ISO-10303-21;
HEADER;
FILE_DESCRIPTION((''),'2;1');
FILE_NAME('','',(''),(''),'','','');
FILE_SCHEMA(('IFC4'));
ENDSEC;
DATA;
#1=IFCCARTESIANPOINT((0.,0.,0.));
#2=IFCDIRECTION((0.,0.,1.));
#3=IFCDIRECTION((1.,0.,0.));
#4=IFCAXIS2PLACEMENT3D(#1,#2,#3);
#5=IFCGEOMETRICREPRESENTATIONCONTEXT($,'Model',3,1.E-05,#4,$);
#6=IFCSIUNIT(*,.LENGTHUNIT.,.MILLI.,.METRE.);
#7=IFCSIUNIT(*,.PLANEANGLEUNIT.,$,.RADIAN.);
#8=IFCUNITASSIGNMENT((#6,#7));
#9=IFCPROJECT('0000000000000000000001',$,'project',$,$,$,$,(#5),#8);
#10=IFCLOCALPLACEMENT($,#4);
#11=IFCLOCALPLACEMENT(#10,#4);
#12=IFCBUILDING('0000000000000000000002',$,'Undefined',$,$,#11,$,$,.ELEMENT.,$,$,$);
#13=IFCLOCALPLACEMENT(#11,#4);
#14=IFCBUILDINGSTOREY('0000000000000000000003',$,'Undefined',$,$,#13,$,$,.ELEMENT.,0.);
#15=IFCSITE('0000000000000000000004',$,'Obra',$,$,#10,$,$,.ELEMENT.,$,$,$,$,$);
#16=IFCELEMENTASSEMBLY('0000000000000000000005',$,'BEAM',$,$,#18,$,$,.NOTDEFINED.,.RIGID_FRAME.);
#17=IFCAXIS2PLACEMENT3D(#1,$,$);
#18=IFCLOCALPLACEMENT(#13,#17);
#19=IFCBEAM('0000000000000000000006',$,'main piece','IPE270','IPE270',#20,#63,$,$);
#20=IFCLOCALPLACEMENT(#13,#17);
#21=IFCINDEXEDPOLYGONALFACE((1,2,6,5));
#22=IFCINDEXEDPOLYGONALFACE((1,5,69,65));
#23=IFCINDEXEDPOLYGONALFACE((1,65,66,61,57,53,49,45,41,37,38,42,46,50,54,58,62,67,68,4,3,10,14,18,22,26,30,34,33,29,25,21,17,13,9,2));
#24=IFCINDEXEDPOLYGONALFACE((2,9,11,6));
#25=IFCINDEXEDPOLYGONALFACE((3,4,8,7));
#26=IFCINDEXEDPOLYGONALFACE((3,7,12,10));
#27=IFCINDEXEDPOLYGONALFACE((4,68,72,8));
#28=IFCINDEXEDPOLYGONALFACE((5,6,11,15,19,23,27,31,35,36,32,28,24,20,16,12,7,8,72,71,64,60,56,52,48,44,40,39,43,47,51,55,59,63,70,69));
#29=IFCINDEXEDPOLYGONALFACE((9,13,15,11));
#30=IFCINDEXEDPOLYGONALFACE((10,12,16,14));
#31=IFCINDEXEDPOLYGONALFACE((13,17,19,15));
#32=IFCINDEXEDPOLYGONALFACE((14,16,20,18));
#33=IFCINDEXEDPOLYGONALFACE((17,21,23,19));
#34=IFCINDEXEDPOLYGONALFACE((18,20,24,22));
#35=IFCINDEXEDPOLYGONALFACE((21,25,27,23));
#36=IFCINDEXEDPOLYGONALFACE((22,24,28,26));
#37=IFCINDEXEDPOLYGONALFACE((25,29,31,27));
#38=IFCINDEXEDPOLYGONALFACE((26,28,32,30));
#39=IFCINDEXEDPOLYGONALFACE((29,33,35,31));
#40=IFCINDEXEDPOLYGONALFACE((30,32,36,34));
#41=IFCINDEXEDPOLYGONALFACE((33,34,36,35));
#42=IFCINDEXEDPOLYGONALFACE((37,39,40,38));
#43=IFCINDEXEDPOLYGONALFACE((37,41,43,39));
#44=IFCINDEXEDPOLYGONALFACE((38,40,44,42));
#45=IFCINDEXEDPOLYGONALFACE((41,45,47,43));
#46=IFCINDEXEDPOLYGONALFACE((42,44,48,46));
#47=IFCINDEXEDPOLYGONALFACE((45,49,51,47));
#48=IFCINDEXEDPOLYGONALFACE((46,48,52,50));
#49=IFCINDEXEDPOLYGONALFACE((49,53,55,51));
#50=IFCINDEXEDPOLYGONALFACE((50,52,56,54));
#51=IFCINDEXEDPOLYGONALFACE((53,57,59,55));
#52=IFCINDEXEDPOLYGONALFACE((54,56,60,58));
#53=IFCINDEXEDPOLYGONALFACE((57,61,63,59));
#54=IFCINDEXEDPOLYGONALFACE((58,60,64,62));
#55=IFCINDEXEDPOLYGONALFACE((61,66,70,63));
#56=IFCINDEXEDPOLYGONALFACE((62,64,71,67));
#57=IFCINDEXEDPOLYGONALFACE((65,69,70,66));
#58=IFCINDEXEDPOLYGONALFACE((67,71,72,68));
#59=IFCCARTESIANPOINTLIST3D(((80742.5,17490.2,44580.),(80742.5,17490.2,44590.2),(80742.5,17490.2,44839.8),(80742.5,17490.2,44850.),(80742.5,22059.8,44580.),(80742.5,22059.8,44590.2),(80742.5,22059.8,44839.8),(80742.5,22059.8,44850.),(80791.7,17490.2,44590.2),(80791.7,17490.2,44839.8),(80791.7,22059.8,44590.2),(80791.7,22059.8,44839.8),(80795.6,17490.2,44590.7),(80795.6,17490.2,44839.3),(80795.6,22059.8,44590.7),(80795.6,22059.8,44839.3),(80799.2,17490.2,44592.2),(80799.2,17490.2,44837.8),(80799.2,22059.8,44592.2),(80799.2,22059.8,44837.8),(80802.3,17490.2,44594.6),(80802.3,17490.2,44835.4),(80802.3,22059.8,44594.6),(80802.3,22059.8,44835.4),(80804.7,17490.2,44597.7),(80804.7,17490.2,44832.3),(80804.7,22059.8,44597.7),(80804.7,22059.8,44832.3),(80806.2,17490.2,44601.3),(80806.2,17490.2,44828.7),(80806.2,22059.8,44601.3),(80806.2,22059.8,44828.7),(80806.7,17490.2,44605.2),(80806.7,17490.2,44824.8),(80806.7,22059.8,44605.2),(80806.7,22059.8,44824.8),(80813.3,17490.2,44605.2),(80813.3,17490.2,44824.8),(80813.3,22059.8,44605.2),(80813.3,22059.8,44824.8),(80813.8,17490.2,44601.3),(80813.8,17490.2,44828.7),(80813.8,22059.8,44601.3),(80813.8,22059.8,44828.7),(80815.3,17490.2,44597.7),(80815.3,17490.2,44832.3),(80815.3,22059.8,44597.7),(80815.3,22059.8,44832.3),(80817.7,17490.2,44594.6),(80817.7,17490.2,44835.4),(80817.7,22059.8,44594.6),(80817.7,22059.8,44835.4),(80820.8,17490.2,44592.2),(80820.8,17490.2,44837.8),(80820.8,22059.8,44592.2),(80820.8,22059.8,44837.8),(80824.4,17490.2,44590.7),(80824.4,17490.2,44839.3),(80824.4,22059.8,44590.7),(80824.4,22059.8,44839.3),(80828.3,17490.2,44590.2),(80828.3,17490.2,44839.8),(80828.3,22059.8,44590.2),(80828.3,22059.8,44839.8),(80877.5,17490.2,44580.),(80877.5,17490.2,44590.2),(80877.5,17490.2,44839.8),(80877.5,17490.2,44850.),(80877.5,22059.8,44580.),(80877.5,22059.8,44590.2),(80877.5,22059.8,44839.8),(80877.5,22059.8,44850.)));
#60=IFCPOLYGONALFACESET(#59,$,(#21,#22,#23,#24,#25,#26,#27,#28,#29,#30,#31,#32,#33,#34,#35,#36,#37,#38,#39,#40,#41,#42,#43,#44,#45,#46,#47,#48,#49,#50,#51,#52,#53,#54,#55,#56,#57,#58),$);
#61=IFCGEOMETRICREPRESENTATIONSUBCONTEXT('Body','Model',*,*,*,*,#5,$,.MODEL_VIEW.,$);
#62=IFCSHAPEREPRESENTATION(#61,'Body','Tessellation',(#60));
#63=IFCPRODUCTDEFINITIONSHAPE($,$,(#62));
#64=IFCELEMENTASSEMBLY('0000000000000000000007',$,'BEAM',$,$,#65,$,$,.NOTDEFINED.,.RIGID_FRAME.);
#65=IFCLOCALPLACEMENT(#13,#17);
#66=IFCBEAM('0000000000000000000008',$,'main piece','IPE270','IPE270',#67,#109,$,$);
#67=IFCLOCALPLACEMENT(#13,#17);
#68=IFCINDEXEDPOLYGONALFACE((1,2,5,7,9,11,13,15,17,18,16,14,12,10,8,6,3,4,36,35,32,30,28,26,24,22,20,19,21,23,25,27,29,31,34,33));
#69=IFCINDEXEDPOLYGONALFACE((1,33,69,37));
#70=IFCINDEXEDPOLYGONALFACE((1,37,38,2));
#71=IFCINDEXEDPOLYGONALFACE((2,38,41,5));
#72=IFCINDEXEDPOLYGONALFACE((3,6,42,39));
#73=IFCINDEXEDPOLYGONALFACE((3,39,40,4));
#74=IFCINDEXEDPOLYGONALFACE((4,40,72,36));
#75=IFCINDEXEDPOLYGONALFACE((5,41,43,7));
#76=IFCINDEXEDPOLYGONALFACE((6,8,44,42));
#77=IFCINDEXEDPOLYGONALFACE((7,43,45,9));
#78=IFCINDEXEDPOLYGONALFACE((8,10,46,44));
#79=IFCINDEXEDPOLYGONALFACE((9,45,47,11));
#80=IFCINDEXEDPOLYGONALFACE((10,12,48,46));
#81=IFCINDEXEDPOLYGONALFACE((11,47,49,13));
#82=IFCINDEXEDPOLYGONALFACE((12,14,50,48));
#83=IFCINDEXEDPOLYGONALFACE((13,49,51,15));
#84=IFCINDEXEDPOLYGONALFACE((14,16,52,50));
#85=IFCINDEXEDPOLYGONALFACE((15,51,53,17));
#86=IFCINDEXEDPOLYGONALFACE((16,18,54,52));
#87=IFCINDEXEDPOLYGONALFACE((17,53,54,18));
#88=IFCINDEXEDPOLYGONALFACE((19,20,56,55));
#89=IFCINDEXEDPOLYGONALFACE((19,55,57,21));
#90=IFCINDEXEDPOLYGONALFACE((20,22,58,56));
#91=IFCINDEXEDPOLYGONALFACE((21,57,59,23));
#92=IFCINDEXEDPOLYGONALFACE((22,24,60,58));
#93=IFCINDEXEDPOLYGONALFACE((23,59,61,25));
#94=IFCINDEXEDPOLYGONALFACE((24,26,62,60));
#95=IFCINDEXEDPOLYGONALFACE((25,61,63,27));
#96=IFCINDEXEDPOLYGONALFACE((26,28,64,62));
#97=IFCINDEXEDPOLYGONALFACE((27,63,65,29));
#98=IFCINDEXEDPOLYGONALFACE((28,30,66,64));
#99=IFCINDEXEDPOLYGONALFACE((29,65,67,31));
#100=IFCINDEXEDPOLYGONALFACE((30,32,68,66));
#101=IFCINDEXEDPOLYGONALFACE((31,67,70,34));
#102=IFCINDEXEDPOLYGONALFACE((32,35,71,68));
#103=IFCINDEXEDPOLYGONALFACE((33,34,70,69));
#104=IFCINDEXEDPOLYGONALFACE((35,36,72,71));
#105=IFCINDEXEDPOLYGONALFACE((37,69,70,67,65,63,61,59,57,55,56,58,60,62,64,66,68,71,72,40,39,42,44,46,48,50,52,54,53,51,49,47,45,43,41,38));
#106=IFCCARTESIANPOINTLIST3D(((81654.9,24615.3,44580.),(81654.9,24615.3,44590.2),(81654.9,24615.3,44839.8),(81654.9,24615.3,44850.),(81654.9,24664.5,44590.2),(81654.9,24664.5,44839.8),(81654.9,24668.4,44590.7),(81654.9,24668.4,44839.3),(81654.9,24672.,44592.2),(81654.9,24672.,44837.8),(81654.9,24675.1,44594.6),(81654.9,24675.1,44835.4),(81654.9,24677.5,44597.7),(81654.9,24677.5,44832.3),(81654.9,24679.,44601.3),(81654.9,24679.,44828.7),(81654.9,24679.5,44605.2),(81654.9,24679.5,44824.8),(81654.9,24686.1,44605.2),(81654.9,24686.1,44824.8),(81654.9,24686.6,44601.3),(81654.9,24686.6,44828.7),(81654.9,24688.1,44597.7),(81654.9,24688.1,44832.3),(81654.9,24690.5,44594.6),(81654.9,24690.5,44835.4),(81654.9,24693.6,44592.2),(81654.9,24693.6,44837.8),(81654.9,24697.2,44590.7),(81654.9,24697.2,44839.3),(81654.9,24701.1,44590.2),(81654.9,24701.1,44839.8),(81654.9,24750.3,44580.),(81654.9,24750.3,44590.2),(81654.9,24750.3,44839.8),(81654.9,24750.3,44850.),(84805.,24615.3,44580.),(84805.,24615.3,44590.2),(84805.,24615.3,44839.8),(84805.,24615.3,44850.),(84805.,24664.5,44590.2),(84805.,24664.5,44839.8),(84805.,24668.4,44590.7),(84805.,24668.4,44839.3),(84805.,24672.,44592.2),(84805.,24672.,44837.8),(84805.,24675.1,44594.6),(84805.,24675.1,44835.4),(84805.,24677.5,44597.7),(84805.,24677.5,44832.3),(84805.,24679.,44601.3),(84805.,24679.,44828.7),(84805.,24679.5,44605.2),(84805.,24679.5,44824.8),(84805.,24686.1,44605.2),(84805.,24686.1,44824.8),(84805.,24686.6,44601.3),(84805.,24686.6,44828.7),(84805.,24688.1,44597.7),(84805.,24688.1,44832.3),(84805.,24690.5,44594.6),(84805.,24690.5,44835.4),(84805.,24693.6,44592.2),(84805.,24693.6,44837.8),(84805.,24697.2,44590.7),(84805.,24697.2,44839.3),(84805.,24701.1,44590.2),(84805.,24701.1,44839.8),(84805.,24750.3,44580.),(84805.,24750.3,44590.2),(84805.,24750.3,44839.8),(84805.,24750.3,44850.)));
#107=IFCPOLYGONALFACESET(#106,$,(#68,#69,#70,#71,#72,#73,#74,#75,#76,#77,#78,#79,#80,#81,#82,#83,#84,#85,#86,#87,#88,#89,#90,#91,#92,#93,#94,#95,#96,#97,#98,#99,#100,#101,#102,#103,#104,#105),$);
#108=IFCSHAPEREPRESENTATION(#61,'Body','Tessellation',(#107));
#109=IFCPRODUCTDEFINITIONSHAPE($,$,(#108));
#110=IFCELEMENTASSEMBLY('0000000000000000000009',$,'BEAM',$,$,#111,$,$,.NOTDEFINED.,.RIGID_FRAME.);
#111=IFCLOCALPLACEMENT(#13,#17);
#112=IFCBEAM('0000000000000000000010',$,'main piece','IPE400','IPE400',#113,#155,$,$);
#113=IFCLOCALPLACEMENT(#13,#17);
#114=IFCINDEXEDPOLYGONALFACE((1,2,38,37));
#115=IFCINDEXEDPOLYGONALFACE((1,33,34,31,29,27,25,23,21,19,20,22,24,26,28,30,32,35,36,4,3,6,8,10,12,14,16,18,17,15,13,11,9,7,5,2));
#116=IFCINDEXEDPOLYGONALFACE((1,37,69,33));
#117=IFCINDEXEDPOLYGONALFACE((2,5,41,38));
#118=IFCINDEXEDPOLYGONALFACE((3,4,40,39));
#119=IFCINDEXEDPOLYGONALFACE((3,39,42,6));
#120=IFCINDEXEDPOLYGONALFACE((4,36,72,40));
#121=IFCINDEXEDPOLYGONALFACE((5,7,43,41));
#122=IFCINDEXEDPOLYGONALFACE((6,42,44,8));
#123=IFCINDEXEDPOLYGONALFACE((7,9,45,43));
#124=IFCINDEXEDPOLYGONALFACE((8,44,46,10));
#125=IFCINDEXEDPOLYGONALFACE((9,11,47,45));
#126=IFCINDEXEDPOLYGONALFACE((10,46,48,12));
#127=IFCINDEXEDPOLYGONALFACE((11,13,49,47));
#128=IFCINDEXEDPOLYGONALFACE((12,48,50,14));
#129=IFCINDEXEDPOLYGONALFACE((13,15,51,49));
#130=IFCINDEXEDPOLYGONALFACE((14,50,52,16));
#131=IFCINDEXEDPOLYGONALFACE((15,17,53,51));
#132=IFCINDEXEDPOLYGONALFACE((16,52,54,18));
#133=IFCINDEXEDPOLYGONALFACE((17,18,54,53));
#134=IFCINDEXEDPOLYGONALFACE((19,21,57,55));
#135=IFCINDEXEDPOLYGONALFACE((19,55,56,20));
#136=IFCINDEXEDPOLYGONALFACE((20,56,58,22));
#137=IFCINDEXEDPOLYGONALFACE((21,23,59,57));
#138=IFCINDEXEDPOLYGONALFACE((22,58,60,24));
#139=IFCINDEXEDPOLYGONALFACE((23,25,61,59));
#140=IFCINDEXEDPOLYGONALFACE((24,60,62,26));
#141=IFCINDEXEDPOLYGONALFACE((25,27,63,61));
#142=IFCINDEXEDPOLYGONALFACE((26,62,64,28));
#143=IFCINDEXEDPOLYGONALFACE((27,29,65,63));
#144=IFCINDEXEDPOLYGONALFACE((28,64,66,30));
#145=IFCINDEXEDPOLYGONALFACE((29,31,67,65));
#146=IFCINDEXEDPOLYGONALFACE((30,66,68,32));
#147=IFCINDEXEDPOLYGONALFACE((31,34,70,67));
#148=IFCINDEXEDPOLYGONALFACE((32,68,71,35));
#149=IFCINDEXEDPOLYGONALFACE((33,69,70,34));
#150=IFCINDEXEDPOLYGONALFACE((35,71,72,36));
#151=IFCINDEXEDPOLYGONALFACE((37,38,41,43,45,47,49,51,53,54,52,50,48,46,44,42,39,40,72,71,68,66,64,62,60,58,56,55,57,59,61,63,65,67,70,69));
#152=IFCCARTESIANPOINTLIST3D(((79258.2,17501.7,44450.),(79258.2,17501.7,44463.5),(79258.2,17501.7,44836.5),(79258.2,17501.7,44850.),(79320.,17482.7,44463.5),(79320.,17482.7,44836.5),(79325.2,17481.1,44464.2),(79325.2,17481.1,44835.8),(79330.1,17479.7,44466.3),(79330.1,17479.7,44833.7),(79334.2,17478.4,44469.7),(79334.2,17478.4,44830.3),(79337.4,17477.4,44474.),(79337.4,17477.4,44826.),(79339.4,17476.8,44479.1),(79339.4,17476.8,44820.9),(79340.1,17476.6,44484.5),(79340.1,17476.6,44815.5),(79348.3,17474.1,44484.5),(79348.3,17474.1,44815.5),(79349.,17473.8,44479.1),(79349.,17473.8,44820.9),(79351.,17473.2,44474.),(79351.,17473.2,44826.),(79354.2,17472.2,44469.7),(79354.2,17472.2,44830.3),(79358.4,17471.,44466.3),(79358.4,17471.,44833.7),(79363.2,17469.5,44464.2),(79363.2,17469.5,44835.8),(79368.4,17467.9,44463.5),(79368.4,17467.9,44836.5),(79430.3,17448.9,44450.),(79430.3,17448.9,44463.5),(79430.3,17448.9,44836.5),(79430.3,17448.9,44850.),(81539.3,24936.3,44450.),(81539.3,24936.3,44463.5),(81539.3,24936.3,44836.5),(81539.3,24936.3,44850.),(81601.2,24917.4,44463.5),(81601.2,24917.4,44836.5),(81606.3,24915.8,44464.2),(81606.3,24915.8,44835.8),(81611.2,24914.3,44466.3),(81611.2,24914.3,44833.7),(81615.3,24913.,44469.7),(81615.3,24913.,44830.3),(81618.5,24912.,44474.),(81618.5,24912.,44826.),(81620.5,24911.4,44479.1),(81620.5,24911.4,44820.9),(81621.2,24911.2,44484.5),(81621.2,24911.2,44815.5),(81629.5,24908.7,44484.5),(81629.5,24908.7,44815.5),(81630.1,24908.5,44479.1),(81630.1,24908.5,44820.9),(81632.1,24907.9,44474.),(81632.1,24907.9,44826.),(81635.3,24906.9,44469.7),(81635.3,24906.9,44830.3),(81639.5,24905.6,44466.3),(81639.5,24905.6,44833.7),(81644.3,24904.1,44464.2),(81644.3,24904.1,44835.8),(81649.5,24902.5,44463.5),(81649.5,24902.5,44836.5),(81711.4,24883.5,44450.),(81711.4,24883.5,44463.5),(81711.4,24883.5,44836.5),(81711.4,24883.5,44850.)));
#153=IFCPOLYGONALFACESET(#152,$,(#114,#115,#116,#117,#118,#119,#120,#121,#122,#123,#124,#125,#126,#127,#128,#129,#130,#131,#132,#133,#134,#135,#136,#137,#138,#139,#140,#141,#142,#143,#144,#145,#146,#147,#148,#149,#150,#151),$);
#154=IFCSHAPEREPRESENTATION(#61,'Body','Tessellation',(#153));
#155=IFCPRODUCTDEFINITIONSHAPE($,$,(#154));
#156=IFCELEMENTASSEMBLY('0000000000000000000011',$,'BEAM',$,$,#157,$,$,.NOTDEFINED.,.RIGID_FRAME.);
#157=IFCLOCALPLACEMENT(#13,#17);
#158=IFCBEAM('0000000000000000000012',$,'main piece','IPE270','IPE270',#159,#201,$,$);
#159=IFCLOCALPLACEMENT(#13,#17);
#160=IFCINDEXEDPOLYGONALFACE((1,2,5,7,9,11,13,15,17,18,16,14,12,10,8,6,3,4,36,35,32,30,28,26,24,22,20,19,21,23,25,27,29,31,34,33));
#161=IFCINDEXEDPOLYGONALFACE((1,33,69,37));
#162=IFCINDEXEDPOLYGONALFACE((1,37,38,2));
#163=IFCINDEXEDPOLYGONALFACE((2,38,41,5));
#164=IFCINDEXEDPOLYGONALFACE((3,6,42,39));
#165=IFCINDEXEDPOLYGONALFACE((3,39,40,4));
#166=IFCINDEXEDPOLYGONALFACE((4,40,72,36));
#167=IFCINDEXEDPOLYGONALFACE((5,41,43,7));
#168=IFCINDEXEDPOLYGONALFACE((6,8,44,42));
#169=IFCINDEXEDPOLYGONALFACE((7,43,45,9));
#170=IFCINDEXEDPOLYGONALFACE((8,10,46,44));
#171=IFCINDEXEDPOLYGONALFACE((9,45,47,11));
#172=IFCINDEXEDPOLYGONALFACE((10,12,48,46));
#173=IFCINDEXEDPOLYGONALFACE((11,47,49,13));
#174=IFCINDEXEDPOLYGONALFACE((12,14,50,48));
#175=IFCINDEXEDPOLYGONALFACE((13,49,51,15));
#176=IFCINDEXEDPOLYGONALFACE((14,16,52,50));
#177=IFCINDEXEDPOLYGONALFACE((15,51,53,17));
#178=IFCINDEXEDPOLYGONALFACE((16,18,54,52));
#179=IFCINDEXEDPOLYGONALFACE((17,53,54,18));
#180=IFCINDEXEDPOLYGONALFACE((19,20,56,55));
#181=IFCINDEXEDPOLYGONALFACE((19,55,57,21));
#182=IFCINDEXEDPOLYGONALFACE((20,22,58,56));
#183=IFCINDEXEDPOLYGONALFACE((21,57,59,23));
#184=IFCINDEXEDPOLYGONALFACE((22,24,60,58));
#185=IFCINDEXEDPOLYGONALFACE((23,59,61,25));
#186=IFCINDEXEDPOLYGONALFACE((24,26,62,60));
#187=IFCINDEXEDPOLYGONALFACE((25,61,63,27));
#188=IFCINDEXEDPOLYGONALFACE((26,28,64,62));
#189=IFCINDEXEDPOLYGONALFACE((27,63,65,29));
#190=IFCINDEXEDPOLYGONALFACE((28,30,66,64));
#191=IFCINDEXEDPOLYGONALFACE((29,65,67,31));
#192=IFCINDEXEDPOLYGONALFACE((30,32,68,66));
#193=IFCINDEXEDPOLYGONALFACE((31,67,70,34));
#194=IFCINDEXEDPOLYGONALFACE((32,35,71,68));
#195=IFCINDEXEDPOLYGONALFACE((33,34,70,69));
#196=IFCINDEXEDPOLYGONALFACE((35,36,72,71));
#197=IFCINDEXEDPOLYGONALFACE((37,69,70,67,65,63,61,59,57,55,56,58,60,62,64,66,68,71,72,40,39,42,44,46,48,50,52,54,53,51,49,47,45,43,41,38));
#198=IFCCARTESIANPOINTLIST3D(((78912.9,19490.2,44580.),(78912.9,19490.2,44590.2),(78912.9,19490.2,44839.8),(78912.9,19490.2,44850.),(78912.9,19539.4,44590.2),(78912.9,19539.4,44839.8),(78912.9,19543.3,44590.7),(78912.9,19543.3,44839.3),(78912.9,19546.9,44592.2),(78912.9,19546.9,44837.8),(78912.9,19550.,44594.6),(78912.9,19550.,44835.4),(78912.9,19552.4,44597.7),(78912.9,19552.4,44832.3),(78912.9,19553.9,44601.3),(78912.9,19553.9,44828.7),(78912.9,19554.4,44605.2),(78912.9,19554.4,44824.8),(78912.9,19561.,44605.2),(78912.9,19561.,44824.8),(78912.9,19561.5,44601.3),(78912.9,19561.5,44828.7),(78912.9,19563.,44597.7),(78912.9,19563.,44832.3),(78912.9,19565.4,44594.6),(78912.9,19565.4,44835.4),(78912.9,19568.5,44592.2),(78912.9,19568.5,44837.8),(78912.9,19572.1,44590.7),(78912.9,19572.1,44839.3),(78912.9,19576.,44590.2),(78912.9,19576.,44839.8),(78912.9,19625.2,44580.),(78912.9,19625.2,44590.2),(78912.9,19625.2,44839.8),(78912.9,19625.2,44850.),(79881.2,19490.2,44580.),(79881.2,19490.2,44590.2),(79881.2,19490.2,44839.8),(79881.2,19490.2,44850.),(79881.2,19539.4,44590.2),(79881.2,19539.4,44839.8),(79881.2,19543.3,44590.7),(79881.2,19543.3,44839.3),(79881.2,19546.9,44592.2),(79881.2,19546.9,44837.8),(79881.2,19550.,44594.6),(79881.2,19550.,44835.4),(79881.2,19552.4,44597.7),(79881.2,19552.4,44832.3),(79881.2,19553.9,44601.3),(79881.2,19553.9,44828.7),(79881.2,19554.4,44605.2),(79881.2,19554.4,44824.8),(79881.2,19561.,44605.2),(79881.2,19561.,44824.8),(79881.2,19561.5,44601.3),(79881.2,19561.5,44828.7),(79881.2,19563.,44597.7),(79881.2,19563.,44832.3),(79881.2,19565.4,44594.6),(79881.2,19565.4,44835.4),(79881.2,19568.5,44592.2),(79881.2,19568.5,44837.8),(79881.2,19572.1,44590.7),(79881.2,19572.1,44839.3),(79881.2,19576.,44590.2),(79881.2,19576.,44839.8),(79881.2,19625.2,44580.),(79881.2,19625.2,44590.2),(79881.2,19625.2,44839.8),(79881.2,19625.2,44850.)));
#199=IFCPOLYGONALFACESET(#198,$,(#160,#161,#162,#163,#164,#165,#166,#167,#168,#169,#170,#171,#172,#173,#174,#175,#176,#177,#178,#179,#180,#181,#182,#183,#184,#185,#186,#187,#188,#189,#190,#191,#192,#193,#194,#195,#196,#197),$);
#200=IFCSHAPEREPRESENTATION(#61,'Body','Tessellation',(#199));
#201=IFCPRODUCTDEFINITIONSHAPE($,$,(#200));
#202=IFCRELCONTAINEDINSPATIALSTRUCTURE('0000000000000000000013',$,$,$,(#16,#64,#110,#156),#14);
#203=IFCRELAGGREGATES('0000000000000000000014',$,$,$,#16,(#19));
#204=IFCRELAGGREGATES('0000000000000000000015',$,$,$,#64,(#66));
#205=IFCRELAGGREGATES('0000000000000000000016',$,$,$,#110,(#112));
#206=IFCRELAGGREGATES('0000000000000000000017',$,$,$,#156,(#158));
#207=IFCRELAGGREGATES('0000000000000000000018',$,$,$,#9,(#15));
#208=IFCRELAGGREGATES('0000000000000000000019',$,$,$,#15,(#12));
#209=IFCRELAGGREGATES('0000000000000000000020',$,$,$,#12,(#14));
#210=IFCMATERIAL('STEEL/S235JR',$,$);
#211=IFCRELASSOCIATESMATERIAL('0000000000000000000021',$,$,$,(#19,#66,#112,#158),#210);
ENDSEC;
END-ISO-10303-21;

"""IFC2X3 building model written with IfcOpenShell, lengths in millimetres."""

from ifc_helpers import new_model, si_unit, frame, origin_with_axes, origin_2d_with_axis, place, context, subcontext, project, spatial, i_section, extrude, material, element, aggregate, save


model = new_model("IFC2X3")

# Units and contexts
model_context = context("Model", 3, precision=1e-05, world=origin_with_axes())
body_context = subcontext(model_context, "Body", "Model", "MODEL_VIEW")
ifc_project = project(units=[si_unit("LENGTHUNIT", "METRE", prefix="MILLI"), si_unit("PLANEANGLEUNIT", "RADIAN")], contexts=[model_context])

# Site, building, storey
site_placement = place(None, origin_with_axes())
site = spatial("IfcSite", under=ifc_project, at=site_placement, Name="Obra", CompositionType="ELEMENT")
building_placement = place(site_placement, origin_with_axes())
building = spatial("IfcBuilding", under=site, at=building_placement, Name="Undefined", CompositionType="ELEMENT")
storey_placement = place(building_placement, origin_with_axes())
storey = spatial("IfcBuildingStorey", under=building, at=storey_placement, Name="Undefined", CompositionType="ELEMENT", Elevation=0.0)

# Shared definitions
ifc_material = material(Name="STEEL/S235JR")

# Element assemblies, beams
assembly_1_placement = place(storey_placement, origin_with_axes())
assembly_1 = element("IfcElementAssembly", 1, at=assembly_1_placement, inside=storey, Name="BEAM", AssemblyPlace="NOTDEFINED", PredefinedType="RIGID_FRAME")
beam_1_placement = place(assembly_1_placement, frame((80810.0, 17490.2, 44715.0), z_axis=(0.0, 0.0, 1.0), x_axis=(0.0, 1.0, 0.0)))
beam_1 = element("IfcBeam", 2, at=beam_1_placement, material=ifc_material, Name="main piece", Description="IPE270", ObjectType="IPE270", context=body_context, shape_type="SweptSolid", body=[
    extrude(i_section(OverallWidth=135.0, OverallDepth=270.0, WebThickness=6.6, FlangeThickness=10.2, FilletRadius=15.0, at=origin_2d_with_axis()), frame((4569.5, 0.0, 0.0), z_axis=(-1.0, 0.0, 0.0), x_axis=(0.0, -1.0, 0.0)), (0.0, 0.0, 1.0), 4569.5),
])
aggregate(assembly_1, [beam_1])
assembly_2_placement = place(storey_placement, origin_with_axes())
assembly_2 = element("IfcElementAssembly", 3, at=assembly_2_placement, inside=storey, Name="BEAM", AssemblyPlace="NOTDEFINED", PredefinedType="RIGID_FRAME")
beam_2_placement = place(assembly_2_placement, frame((81654.9, 24682.8, 44715.0), z_axis=(0.0, 0.0, 1.0), x_axis=(1.0, 0.0, 0.0)))
beam_2 = element("IfcBeam", 4, at=beam_2_placement, material=ifc_material, Name="main piece", Description="IPE270", ObjectType="IPE270", context=body_context, shape_type="SweptSolid", body=[
    extrude(i_section(OverallWidth=135.0, OverallDepth=270.0, WebThickness=6.6, FlangeThickness=10.2, FilletRadius=15.0, at=origin_2d_with_axis()), frame((3150.1, 0.0, 0.0), z_axis=(-1.0, 0.0, 0.0), x_axis=(0.0, -1.0, 0.0)), (0.0, 0.0, 1.0), 3150.1),
])
aggregate(assembly_2, [beam_2])
assembly_3_placement = place(storey_placement, origin_with_axes())
assembly_3 = element("IfcElementAssembly", 5, at=assembly_3_placement, inside=storey, Name="BEAM", AssemblyPlace="NOTDEFINED", PredefinedType="RIGID_FRAME")
beam_3_placement = place(assembly_3_placement, frame((79344.2, 17475.3, 44650.0), z_axis=(0.0, 0.0, 1.0), x_axis=(0.293326, 0.956013, 0.0)))
beam_3 = element("IfcBeam", 6, at=beam_3_placement, material=ifc_material, Name="main piece", Description="IPE400", ObjectType="IPE400", context=body_context, shape_type="SweptSolid", body=[
    extrude(i_section(OverallWidth=180.0, OverallDepth=400.0, WebThickness=8.6, FlangeThickness=13.5, FilletRadius=21.0, at=origin_2d_with_axis()), frame((7776.7, 0.0, 0.0), z_axis=(-1.0, 0.0, 0.0), x_axis=(0.0, -1.0, 0.0)), (0.0, 0.0, 1.0), 7776.7),
])
aggregate(assembly_3, [beam_3])
assembly_4_placement = place(storey_placement, origin_with_axes())
assembly_4 = element("IfcElementAssembly", 7, at=assembly_4_placement, inside=storey, Name="BEAM", AssemblyPlace="NOTDEFINED", PredefinedType="RIGID_FRAME")
beam_4_placement = place(assembly_4_placement, frame((78912.9, 19557.7, 44715.0), z_axis=(0.0, 0.0, 1.0), x_axis=(1.0, 0.0, 0.0)))
beam_4 = element("IfcBeam", 8, at=beam_4_placement, material=ifc_material, Name="main piece", Description="IPE270", ObjectType="IPE270", context=body_context, shape_type="SweptSolid", body=[
    extrude(i_section(OverallWidth=135.0, OverallDepth=270.0, WebThickness=6.6, FlangeThickness=10.2, FilletRadius=15.0, at=origin_2d_with_axis()), frame((968.2, 0.0, 0.0), z_axis=(-1.0, 0.0, 0.0), x_axis=(0.0, -1.0, 0.0)), (0.0, 0.0, 1.0), 968.2),
])
aggregate(assembly_4, [beam_4])

save(model, "model.ifc")
